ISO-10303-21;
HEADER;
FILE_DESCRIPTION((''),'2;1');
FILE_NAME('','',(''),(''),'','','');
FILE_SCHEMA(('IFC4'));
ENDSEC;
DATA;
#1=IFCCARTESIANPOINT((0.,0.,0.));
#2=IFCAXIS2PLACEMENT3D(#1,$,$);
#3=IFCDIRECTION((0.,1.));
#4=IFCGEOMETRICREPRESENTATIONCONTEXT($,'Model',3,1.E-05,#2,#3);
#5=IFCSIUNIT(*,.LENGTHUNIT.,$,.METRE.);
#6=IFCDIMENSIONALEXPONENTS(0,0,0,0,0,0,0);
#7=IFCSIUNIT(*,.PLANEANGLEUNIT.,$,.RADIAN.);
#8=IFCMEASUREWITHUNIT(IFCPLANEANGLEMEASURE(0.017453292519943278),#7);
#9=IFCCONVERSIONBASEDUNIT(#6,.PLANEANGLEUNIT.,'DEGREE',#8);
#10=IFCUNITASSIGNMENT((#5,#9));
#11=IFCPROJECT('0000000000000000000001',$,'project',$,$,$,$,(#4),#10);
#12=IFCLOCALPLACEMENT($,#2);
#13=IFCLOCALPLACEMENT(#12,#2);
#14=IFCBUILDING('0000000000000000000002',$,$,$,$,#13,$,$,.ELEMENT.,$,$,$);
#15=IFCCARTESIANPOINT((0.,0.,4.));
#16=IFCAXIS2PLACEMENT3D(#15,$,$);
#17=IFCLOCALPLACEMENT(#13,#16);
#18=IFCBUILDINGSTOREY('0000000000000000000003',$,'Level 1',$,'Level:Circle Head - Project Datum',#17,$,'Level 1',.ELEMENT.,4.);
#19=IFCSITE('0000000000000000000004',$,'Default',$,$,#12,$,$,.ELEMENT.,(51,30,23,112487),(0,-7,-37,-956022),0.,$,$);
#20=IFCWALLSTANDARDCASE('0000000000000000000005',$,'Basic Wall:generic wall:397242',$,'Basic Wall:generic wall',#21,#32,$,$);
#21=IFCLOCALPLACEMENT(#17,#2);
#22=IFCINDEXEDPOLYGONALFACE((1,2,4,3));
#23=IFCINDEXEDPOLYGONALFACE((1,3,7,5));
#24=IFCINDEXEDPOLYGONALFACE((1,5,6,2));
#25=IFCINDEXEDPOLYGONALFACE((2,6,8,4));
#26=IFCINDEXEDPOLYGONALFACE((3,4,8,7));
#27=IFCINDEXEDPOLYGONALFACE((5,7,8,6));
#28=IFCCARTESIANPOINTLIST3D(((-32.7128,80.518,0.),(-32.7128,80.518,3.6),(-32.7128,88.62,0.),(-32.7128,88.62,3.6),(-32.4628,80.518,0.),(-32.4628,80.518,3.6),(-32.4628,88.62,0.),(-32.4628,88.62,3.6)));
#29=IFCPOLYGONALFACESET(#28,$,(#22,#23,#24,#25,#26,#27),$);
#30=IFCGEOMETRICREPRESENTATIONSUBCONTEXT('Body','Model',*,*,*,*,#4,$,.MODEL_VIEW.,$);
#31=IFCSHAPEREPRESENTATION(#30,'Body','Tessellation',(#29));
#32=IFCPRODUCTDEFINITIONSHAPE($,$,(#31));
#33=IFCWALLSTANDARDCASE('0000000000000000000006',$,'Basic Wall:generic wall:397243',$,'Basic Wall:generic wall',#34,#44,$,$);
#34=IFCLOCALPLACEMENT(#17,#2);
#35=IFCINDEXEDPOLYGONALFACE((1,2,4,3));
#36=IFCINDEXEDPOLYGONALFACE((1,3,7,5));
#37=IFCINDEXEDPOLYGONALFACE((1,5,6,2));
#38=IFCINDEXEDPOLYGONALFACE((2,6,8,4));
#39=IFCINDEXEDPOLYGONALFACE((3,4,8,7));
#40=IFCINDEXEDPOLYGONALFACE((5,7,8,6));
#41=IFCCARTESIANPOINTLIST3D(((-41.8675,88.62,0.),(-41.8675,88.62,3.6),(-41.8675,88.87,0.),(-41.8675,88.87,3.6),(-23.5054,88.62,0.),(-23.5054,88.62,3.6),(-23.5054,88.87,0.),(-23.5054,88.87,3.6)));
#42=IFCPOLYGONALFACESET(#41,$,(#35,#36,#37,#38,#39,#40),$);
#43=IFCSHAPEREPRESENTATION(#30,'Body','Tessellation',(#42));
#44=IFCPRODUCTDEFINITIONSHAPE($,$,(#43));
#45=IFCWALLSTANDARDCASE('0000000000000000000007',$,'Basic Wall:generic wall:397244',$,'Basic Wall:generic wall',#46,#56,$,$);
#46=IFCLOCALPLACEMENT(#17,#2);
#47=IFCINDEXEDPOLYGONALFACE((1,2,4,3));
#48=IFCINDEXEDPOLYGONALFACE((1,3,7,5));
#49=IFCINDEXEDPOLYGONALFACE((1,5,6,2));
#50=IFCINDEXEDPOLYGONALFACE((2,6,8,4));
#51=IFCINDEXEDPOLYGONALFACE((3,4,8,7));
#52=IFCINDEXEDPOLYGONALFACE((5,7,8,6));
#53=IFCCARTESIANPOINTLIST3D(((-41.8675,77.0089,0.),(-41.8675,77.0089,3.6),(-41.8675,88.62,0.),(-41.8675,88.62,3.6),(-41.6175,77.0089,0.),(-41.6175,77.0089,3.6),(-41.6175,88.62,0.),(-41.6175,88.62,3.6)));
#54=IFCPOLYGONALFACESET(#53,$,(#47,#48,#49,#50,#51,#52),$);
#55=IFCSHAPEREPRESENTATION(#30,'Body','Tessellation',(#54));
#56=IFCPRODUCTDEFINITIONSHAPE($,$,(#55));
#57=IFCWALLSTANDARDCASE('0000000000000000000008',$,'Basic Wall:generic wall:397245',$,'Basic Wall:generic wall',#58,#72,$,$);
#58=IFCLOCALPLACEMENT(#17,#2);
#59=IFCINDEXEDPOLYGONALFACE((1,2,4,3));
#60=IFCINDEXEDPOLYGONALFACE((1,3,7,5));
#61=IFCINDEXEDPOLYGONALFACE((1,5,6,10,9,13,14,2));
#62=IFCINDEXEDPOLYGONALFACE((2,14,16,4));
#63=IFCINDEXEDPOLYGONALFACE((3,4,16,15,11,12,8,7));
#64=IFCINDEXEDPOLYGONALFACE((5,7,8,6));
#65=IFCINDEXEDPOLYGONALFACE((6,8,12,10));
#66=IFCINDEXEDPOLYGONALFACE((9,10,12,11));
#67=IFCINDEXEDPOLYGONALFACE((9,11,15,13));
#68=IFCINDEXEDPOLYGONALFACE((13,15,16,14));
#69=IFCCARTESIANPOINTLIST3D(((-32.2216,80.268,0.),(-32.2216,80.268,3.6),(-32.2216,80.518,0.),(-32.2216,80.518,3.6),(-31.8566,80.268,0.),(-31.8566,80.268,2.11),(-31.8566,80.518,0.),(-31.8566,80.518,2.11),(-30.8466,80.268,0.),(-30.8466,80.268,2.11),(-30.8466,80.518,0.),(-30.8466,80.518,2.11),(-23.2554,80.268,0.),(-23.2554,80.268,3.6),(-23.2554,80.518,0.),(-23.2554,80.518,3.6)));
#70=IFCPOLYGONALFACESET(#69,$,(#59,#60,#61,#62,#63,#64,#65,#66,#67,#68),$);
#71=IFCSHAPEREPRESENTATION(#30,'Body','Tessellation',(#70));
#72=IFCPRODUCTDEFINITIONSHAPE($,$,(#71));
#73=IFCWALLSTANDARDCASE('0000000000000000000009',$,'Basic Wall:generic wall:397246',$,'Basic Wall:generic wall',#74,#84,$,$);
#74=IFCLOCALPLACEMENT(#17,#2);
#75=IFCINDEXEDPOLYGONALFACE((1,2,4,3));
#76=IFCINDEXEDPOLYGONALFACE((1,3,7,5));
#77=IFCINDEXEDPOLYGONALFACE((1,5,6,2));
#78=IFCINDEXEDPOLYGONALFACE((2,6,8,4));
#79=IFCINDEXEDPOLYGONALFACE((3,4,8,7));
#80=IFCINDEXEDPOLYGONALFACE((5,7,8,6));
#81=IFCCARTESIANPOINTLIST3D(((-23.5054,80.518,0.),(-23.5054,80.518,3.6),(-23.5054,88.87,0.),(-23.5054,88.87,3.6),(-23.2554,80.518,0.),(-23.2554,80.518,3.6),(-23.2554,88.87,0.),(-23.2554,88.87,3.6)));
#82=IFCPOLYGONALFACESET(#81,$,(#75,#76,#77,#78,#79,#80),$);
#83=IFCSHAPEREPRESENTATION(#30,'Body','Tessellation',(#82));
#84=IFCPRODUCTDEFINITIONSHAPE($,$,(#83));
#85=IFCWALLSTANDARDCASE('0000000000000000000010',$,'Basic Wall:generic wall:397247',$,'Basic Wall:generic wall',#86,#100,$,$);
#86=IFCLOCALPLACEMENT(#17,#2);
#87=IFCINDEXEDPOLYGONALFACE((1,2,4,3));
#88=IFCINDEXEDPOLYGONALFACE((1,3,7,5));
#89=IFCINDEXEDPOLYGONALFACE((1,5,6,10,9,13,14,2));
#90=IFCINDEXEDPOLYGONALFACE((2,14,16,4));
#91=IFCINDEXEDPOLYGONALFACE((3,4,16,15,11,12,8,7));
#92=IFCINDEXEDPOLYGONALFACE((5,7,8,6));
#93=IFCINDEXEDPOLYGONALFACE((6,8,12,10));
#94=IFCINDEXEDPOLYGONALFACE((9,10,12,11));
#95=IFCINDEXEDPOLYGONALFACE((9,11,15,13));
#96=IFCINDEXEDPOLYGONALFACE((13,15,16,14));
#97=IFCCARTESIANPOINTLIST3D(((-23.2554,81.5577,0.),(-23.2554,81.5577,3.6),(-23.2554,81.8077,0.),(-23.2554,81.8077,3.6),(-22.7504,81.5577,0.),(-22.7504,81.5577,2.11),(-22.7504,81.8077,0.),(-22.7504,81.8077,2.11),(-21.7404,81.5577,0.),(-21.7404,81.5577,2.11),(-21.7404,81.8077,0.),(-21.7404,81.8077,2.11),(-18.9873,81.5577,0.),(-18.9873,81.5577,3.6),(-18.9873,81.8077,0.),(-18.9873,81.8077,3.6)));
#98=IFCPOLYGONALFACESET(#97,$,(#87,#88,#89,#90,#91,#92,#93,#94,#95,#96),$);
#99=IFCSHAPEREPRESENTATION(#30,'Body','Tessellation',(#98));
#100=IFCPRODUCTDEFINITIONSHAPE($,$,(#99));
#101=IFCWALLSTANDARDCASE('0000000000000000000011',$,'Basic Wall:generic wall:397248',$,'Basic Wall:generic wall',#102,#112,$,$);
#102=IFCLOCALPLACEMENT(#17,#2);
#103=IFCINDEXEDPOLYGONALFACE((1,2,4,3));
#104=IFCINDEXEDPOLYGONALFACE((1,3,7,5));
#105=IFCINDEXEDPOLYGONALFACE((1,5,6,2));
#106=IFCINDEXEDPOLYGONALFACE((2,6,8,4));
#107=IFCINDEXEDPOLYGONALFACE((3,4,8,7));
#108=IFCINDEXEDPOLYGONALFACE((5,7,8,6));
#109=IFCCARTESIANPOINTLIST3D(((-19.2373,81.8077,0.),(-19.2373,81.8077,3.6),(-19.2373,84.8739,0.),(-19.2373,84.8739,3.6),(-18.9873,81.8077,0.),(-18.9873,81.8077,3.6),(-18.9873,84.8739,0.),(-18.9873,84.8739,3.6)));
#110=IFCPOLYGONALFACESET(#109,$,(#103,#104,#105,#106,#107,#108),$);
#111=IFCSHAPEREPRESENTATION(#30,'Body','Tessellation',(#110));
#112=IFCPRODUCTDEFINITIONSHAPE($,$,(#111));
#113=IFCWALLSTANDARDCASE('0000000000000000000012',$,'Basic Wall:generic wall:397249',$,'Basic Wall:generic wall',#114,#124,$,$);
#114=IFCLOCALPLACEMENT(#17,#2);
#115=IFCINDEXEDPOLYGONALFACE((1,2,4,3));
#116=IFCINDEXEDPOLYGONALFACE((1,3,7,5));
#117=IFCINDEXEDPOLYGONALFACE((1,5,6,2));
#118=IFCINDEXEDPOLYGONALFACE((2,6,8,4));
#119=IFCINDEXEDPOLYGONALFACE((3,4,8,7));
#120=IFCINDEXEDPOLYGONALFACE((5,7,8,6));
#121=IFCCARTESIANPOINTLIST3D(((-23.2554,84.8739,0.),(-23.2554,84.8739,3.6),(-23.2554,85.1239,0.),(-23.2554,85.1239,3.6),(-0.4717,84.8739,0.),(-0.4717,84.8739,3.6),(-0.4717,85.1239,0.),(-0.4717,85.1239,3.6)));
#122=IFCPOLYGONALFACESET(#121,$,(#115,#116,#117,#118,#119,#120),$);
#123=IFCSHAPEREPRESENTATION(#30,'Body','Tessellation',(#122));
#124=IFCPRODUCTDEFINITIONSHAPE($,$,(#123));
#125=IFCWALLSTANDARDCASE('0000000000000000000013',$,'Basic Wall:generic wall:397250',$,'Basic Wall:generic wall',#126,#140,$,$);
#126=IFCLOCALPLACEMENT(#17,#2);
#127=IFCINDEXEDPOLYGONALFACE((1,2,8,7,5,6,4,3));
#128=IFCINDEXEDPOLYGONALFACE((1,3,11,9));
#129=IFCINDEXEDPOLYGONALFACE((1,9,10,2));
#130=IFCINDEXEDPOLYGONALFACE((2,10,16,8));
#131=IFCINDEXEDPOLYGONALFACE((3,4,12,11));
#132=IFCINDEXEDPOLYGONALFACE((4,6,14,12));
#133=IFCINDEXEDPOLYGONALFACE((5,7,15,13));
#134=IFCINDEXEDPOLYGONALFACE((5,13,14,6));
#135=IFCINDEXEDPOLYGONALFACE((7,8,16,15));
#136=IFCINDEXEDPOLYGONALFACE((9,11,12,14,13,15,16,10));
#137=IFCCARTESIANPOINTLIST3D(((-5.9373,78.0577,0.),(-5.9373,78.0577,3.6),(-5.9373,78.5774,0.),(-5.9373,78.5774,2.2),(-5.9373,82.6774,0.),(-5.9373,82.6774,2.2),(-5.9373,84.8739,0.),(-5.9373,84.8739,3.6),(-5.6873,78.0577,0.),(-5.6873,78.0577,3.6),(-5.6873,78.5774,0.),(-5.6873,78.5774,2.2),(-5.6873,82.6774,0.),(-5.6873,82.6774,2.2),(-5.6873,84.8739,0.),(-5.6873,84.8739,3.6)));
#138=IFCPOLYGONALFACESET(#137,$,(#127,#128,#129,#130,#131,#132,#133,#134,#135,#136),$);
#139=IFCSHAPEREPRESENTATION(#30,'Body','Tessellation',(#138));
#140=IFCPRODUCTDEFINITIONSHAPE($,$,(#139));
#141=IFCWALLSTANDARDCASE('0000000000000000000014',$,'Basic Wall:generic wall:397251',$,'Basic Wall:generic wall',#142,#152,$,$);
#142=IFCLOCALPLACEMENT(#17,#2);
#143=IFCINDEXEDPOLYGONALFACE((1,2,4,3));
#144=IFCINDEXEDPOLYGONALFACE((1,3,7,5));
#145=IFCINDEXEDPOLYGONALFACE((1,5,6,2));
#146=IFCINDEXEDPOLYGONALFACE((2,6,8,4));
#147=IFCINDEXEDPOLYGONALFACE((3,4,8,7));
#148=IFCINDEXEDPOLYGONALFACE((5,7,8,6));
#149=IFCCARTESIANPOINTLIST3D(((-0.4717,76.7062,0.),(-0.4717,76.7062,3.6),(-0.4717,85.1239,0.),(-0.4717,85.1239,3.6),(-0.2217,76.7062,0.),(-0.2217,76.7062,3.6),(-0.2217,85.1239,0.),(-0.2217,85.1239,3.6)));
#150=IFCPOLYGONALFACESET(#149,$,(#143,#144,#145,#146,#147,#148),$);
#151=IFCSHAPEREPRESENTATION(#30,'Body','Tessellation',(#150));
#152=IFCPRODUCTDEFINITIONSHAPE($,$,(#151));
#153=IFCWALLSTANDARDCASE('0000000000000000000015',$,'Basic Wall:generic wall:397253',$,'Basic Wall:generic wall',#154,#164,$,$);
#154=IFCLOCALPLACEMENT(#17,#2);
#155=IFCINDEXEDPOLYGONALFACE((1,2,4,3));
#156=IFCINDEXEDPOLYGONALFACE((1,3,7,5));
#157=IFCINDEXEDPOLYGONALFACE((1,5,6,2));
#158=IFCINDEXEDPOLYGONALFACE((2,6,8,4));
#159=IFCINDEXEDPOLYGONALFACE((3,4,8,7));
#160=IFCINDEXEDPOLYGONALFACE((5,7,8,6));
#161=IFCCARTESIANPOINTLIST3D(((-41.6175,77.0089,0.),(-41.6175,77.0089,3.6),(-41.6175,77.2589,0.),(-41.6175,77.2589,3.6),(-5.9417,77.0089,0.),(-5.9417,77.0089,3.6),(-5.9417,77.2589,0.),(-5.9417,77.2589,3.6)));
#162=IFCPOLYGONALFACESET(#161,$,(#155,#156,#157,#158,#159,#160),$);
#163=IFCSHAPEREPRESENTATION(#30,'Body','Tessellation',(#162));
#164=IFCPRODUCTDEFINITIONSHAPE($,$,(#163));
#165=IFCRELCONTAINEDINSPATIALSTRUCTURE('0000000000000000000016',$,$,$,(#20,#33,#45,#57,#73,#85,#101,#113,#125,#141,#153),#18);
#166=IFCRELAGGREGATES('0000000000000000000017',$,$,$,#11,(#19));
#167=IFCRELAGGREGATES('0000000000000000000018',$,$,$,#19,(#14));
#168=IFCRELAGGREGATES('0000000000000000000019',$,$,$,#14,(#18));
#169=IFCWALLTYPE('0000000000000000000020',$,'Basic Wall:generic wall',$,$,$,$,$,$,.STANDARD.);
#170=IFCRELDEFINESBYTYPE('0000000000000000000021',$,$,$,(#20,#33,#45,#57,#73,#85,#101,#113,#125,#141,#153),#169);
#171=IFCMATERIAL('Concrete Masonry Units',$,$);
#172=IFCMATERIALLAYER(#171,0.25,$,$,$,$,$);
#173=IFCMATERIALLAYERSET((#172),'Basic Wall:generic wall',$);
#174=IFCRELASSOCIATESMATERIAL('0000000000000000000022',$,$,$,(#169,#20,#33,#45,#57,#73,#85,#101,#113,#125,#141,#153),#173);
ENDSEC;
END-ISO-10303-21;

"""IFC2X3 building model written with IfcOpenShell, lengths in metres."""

from ifc_helpers import new_model, entity, si_unit, converted_unit, direction, frame, frame_2d, origin, place, context, subcontext, project, spatial, rectangle, extrude, material, layer, layer_set, layer_usage, type_object, element, save


model = new_model("IFC2X3")

# Units and contexts
model_context = context("Model", 3, precision=1e-05, world=origin(), true_north=direction((0.0, 1.0)))
body_context = subcontext(model_context, "Body", "Model", "MODEL_VIEW")
ifc_project = project(units=[si_unit("LENGTHUNIT", "METRE"), converted_unit("PLANEANGLEUNIT", "DEGREE", entity("IfcPlaneAngleMeasure", 0.017453292519943278), si_unit("PLANEANGLEUNIT", "RADIAN"), dimensions=[0, 0, 0, 0, 0, 0, 0])], contexts=[model_context])

# Site, building, storey
site_placement = place(None, origin())
site = spatial("IfcSite", under=ifc_project, at=site_placement, Name="Default", CompositionType="ELEMENT", RefLatitude=(51, 30, 23, 112487), RefLongitude=(0, -7, -37, -956022), RefElevation=0.0)
building_placement = place(site_placement, origin())
building = spatial("IfcBuilding", under=site, at=building_placement, CompositionType="ELEMENT")
storey_placement = place(building_placement, frame((0.0, 0.0, 4.0)))
storey = spatial("IfcBuildingStorey", under=building, at=storey_placement, Name="Level 1", ObjectType="Level:Circle Head - Project Datum", LongName="Level 1", CompositionType="ELEMENT", Elevation=4.0)

# Walls
ifc_material = material(Name="Concrete Masonry Units")
ifc_layer = layer(ifc_material, 0.25)
ifc_layer_set = layer_set([ifc_layer], Name="Basic Wall:generic wall")
ifc_layer_usage_1 = layer_usage(ifc_layer_set, "AXIS2", "NEGATIVE", 0.125)
wall_type = type_object("IfcWallType", Name="Basic Wall:generic wall", PredefinedType="STANDARD", material=ifc_layer_set)
wall_1_placement = place(storey_placement, frame((-32.5878, 80.518, 0.0), z_axis=(0.0, 0.0, 1.0), x_axis=(0.0, 1.0, 0.0)))
element("IfcWallStandardCase", 1, at=wall_1_placement, inside=storey, type_object=wall_type, material=ifc_layer_usage_1, Name="Basic Wall:generic wall:397242", ObjectType="Basic Wall:generic wall", context=body_context, shape_type="SweptSolid", body=[
    extrude(rectangle(XDim=8.102, YDim=0.25, at=frame_2d((4.051, 0.0), x_axis=(-1.0, 0.0))), origin(), (0.0, 0.0, 1.0), 3.6),
])
ifc_layer_usage_2 = layer_usage(ifc_layer_set, "AXIS2", "NEGATIVE", 0.125)
wall_2_placement = place(storey_placement, frame((-23.5054, 88.745, 0.0), z_axis=(0.0, 0.0, 1.0), x_axis=(-1.0, 0.0, 0.0)))
element("IfcWallStandardCase", 2, at=wall_2_placement, inside=storey, type_object=wall_type, material=ifc_layer_usage_2, Name="Basic Wall:generic wall:397243", ObjectType="Basic Wall:generic wall", context=body_context, shape_type="SweptSolid", body=[
    extrude(rectangle(XDim=18.3621, YDim=0.25, at=frame_2d((9.1811, 0.0), x_axis=(-1.0, 0.0))), origin(), (0.0, 0.0, 1.0), 3.6),
])
ifc_layer_usage_3 = layer_usage(ifc_layer_set, "AXIS2", "NEGATIVE", 0.125)
wall_3_placement = place(storey_placement, frame((-41.7425, 88.62, 0.0), z_axis=(0.0, 0.0, 1.0), x_axis=(0.0, -1.0, 0.0)))
element("IfcWallStandardCase", 3, at=wall_3_placement, inside=storey, type_object=wall_type, material=ifc_layer_usage_3, Name="Basic Wall:generic wall:397244", ObjectType="Basic Wall:generic wall", context=body_context, shape_type="SweptSolid", body=[
    extrude(rectangle(XDim=11.6112, YDim=0.25, at=frame_2d((5.8056, 0.0), x_axis=(-1.0, 0.0))), origin(), (0.0, 0.0, 1.0), 3.6),
])

# Wall, opening
ifc_layer_usage_4 = layer_usage(ifc_layer_set, "AXIS2", "NEGATIVE", 0.125)
wall_4_placement = place(storey_placement, frame((-23.2554, 80.393, 0.0), z_axis=(0.0, 0.0, 1.0), x_axis=(-1.0, 0.0, 0.0)))
wall_4 = element("IfcWallStandardCase", 4, at=wall_4_placement, inside=storey, type_object=wall_type, material=ifc_layer_usage_4, Name="Basic Wall:generic wall:397245", ObjectType="Basic Wall:generic wall", context=body_context, shape_type="SweptSolid", body=[
    extrude(rectangle(XDim=8.9661, YDim=0.25, at=frame_2d((4.4831, 0.0), x_axis=(-1.0, 0.0))), origin(), (0.0, 0.0, 1.0), 3.6),
])
opening_1_placement = place(wall_4_placement, frame((8.6011, 0.125, 0.0)))
element("IfcOpeningElement", 5, at=opening_1_placement, cuts=wall_4, ObjectType="Opening", context=body_context, shape_type="SweptSolid", body=[
    extrude(rectangle(XDim=2.11, YDim=1.01, at=frame_2d((1.055, 0.505), x_axis=(1.0, 0.0))), frame((0.0, 0.0, 0.0), z_axis=(0.0, -1.0, 0.0), x_axis=(0.0, 0.0, 1.0)), (0.0, 0.0, 1.0), 0.25),
])

# Wall
ifc_layer_usage_5 = layer_usage(ifc_layer_set, "AXIS2", "NEGATIVE", 0.125)
wall_5_placement = place(storey_placement, frame((-23.3804, 88.87, 0.0), z_axis=(0.0, 0.0, 1.0), x_axis=(0.0, -1.0, 0.0)))
element("IfcWallStandardCase", 6, at=wall_5_placement, inside=storey, type_object=wall_type, material=ifc_layer_usage_5, Name="Basic Wall:generic wall:397246", ObjectType="Basic Wall:generic wall", context=body_context, shape_type="SweptSolid", body=[
    extrude(rectangle(XDim=8.352, YDim=0.25, at=frame_2d((4.176, 0.0), x_axis=(-1.0, 0.0))), origin(), (0.0, 0.0, 1.0), 3.6),
])

# Wall, opening
ifc_layer_usage_6 = layer_usage(ifc_layer_set, "AXIS2", "NEGATIVE", 0.125)
wall_6_placement = place(storey_placement, frame((-18.9873, 81.6827, 0.0), z_axis=(0.0, 0.0, 1.0), x_axis=(-1.0, 0.0, 0.0)))
wall_6 = element("IfcWallStandardCase", 7, at=wall_6_placement, inside=storey, type_object=wall_type, material=ifc_layer_usage_6, Name="Basic Wall:generic wall:397247", ObjectType="Basic Wall:generic wall", context=body_context, shape_type="SweptSolid", body=[
    extrude(rectangle(XDim=4.2681, YDim=0.25, at=frame_2d((2.1341, 0.0), x_axis=(-1.0, 0.0))), origin(), (0.0, 0.0, 1.0), 3.6),
])
opening_2_placement = place(wall_6_placement, frame((3.7631, 0.125, 0.0)))
element("IfcOpeningElement", 8, at=opening_2_placement, cuts=wall_6, ObjectType="Opening", context=body_context, shape_type="SweptSolid", body=[
    extrude(rectangle(XDim=2.11, YDim=1.01, at=frame_2d((1.055, 0.505), x_axis=(1.0, 0.0))), frame((0.0, 0.0, 0.0), z_axis=(0.0, -1.0, 0.0), x_axis=(0.0, 0.0, 1.0)), (0.0, 0.0, 1.0), 0.25),
])

# Walls
ifc_layer_usage_7 = layer_usage(ifc_layer_set, "AXIS2", "NEGATIVE", 0.125)
wall_7_placement = place(storey_placement, frame((-19.1123, 84.8739, 0.0), z_axis=(0.0, 0.0, 1.0), x_axis=(0.0, -1.0, 0.0)))
element("IfcWallStandardCase", 9, at=wall_7_placement, inside=storey, type_object=wall_type, material=ifc_layer_usage_7, Name="Basic Wall:generic wall:397248", ObjectType="Basic Wall:generic wall", context=body_context, shape_type="SweptSolid", body=[
    extrude(rectangle(XDim=3.0662, YDim=0.25, at=frame_2d((1.5331, 0.0), x_axis=(-1.0, 0.0))), origin(), (0.0, 0.0, 1.0), 3.6),
])
ifc_layer_usage_8 = layer_usage(ifc_layer_set, "AXIS2", "NEGATIVE", 0.125)
wall_8_placement = place(storey_placement, frame((-0.4717, 84.9989, 0.0), z_axis=(0.0, 0.0, 1.0), x_axis=(-1.0, 0.0, 0.0)))
element("IfcWallStandardCase", 10, at=wall_8_placement, inside=storey, type_object=wall_type, material=ifc_layer_usage_8, Name="Basic Wall:generic wall:397249", ObjectType="Basic Wall:generic wall", context=body_context, shape_type="SweptSolid", body=[
    extrude(rectangle(XDim=22.7838, YDim=0.25, at=frame_2d((11.3919, 0.0), x_axis=(-1.0, 0.0))), origin(), (0.0, 0.0, 1.0), 3.6),
])

# Wall, opening
ifc_layer_usage_9 = layer_usage(ifc_layer_set, "AXIS2", "NEGATIVE", 0.125)
wall_9_placement = place(storey_placement, frame((-5.8123, 78.0577, 0.0), z_axis=(0.0, 0.0, 1.0), x_axis=(0.0, 1.0, 0.0)))
wall_9 = element("IfcWallStandardCase", 11, at=wall_9_placement, inside=storey, type_object=wall_type, material=ifc_layer_usage_9, Name="Basic Wall:generic wall:397250", ObjectType="Basic Wall:generic wall", context=body_context, shape_type="SweptSolid", body=[
    extrude(rectangle(XDim=6.8162, YDim=0.25, at=frame_2d((3.4081, 0.0), x_axis=(1.0, 0.0))), origin(), (0.0, 0.0, 1.0), 3.6),
])
opening_3_placement = place(wall_9_placement, frame((4.6198, 0.125, 0.0)))
element("IfcOpeningElement", 12, at=opening_3_placement, cuts=wall_9, ObjectType="Opening", context=body_context, shape_type="SweptSolid", body=[
    extrude(rectangle(XDim=2.2, YDim=4.1, at=frame_2d((1.1, 2.05), x_axis=(1.0, 0.0))), frame((0.0, 0.0, 0.0), z_axis=(0.0, -1.0, 0.0), x_axis=(0.0, 0.0, 1.0)), (0.0, 0.0, 1.0), 0.25),
])

# Walls
ifc_layer_usage_10 = layer_usage(ifc_layer_set, "AXIS2", "POSITIVE", -0.125)
wall_10_placement = place(storey_placement, frame((-0.3467, 85.1239, 0.0), z_axis=(0.0, 0.0, 1.0), x_axis=(0.0, -1.0, 0.0)))
element("IfcWallStandardCase", 13, at=wall_10_placement, inside=storey, type_object=wall_type, material=ifc_layer_usage_10, Name="Basic Wall:generic wall:397251", ObjectType="Basic Wall:generic wall", context=body_context, shape_type="SweptSolid", body=[
    extrude(rectangle(XDim=8.4178, YDim=0.25, at=frame_2d((4.2089, 0.0), x_axis=(-1.0, 0.0))), origin(), (0.0, 0.0, 1.0), 3.6),
])
ifc_layer_usage_11 = layer_usage(ifc_layer_set, "AXIS2", "NEGATIVE", 0.125)
wall_11_placement = place(storey_placement, frame((-41.6175, 77.1339, 0.0)))
element("IfcWallStandardCase", 14, at=wall_11_placement, inside=storey, type_object=wall_type, material=ifc_layer_usage_11, Name="Basic Wall:generic wall:397253", ObjectType="Basic Wall:generic wall", context=body_context, shape_type="SweptSolid", body=[
    extrude(rectangle(XDim=35.6759, YDim=0.25, at=frame_2d((17.8379, 0.0), x_axis=(-1.0, 0.0))), origin(), (0.0, 0.0, 1.0), 3.6),
])

save(model, "model.ifc")
